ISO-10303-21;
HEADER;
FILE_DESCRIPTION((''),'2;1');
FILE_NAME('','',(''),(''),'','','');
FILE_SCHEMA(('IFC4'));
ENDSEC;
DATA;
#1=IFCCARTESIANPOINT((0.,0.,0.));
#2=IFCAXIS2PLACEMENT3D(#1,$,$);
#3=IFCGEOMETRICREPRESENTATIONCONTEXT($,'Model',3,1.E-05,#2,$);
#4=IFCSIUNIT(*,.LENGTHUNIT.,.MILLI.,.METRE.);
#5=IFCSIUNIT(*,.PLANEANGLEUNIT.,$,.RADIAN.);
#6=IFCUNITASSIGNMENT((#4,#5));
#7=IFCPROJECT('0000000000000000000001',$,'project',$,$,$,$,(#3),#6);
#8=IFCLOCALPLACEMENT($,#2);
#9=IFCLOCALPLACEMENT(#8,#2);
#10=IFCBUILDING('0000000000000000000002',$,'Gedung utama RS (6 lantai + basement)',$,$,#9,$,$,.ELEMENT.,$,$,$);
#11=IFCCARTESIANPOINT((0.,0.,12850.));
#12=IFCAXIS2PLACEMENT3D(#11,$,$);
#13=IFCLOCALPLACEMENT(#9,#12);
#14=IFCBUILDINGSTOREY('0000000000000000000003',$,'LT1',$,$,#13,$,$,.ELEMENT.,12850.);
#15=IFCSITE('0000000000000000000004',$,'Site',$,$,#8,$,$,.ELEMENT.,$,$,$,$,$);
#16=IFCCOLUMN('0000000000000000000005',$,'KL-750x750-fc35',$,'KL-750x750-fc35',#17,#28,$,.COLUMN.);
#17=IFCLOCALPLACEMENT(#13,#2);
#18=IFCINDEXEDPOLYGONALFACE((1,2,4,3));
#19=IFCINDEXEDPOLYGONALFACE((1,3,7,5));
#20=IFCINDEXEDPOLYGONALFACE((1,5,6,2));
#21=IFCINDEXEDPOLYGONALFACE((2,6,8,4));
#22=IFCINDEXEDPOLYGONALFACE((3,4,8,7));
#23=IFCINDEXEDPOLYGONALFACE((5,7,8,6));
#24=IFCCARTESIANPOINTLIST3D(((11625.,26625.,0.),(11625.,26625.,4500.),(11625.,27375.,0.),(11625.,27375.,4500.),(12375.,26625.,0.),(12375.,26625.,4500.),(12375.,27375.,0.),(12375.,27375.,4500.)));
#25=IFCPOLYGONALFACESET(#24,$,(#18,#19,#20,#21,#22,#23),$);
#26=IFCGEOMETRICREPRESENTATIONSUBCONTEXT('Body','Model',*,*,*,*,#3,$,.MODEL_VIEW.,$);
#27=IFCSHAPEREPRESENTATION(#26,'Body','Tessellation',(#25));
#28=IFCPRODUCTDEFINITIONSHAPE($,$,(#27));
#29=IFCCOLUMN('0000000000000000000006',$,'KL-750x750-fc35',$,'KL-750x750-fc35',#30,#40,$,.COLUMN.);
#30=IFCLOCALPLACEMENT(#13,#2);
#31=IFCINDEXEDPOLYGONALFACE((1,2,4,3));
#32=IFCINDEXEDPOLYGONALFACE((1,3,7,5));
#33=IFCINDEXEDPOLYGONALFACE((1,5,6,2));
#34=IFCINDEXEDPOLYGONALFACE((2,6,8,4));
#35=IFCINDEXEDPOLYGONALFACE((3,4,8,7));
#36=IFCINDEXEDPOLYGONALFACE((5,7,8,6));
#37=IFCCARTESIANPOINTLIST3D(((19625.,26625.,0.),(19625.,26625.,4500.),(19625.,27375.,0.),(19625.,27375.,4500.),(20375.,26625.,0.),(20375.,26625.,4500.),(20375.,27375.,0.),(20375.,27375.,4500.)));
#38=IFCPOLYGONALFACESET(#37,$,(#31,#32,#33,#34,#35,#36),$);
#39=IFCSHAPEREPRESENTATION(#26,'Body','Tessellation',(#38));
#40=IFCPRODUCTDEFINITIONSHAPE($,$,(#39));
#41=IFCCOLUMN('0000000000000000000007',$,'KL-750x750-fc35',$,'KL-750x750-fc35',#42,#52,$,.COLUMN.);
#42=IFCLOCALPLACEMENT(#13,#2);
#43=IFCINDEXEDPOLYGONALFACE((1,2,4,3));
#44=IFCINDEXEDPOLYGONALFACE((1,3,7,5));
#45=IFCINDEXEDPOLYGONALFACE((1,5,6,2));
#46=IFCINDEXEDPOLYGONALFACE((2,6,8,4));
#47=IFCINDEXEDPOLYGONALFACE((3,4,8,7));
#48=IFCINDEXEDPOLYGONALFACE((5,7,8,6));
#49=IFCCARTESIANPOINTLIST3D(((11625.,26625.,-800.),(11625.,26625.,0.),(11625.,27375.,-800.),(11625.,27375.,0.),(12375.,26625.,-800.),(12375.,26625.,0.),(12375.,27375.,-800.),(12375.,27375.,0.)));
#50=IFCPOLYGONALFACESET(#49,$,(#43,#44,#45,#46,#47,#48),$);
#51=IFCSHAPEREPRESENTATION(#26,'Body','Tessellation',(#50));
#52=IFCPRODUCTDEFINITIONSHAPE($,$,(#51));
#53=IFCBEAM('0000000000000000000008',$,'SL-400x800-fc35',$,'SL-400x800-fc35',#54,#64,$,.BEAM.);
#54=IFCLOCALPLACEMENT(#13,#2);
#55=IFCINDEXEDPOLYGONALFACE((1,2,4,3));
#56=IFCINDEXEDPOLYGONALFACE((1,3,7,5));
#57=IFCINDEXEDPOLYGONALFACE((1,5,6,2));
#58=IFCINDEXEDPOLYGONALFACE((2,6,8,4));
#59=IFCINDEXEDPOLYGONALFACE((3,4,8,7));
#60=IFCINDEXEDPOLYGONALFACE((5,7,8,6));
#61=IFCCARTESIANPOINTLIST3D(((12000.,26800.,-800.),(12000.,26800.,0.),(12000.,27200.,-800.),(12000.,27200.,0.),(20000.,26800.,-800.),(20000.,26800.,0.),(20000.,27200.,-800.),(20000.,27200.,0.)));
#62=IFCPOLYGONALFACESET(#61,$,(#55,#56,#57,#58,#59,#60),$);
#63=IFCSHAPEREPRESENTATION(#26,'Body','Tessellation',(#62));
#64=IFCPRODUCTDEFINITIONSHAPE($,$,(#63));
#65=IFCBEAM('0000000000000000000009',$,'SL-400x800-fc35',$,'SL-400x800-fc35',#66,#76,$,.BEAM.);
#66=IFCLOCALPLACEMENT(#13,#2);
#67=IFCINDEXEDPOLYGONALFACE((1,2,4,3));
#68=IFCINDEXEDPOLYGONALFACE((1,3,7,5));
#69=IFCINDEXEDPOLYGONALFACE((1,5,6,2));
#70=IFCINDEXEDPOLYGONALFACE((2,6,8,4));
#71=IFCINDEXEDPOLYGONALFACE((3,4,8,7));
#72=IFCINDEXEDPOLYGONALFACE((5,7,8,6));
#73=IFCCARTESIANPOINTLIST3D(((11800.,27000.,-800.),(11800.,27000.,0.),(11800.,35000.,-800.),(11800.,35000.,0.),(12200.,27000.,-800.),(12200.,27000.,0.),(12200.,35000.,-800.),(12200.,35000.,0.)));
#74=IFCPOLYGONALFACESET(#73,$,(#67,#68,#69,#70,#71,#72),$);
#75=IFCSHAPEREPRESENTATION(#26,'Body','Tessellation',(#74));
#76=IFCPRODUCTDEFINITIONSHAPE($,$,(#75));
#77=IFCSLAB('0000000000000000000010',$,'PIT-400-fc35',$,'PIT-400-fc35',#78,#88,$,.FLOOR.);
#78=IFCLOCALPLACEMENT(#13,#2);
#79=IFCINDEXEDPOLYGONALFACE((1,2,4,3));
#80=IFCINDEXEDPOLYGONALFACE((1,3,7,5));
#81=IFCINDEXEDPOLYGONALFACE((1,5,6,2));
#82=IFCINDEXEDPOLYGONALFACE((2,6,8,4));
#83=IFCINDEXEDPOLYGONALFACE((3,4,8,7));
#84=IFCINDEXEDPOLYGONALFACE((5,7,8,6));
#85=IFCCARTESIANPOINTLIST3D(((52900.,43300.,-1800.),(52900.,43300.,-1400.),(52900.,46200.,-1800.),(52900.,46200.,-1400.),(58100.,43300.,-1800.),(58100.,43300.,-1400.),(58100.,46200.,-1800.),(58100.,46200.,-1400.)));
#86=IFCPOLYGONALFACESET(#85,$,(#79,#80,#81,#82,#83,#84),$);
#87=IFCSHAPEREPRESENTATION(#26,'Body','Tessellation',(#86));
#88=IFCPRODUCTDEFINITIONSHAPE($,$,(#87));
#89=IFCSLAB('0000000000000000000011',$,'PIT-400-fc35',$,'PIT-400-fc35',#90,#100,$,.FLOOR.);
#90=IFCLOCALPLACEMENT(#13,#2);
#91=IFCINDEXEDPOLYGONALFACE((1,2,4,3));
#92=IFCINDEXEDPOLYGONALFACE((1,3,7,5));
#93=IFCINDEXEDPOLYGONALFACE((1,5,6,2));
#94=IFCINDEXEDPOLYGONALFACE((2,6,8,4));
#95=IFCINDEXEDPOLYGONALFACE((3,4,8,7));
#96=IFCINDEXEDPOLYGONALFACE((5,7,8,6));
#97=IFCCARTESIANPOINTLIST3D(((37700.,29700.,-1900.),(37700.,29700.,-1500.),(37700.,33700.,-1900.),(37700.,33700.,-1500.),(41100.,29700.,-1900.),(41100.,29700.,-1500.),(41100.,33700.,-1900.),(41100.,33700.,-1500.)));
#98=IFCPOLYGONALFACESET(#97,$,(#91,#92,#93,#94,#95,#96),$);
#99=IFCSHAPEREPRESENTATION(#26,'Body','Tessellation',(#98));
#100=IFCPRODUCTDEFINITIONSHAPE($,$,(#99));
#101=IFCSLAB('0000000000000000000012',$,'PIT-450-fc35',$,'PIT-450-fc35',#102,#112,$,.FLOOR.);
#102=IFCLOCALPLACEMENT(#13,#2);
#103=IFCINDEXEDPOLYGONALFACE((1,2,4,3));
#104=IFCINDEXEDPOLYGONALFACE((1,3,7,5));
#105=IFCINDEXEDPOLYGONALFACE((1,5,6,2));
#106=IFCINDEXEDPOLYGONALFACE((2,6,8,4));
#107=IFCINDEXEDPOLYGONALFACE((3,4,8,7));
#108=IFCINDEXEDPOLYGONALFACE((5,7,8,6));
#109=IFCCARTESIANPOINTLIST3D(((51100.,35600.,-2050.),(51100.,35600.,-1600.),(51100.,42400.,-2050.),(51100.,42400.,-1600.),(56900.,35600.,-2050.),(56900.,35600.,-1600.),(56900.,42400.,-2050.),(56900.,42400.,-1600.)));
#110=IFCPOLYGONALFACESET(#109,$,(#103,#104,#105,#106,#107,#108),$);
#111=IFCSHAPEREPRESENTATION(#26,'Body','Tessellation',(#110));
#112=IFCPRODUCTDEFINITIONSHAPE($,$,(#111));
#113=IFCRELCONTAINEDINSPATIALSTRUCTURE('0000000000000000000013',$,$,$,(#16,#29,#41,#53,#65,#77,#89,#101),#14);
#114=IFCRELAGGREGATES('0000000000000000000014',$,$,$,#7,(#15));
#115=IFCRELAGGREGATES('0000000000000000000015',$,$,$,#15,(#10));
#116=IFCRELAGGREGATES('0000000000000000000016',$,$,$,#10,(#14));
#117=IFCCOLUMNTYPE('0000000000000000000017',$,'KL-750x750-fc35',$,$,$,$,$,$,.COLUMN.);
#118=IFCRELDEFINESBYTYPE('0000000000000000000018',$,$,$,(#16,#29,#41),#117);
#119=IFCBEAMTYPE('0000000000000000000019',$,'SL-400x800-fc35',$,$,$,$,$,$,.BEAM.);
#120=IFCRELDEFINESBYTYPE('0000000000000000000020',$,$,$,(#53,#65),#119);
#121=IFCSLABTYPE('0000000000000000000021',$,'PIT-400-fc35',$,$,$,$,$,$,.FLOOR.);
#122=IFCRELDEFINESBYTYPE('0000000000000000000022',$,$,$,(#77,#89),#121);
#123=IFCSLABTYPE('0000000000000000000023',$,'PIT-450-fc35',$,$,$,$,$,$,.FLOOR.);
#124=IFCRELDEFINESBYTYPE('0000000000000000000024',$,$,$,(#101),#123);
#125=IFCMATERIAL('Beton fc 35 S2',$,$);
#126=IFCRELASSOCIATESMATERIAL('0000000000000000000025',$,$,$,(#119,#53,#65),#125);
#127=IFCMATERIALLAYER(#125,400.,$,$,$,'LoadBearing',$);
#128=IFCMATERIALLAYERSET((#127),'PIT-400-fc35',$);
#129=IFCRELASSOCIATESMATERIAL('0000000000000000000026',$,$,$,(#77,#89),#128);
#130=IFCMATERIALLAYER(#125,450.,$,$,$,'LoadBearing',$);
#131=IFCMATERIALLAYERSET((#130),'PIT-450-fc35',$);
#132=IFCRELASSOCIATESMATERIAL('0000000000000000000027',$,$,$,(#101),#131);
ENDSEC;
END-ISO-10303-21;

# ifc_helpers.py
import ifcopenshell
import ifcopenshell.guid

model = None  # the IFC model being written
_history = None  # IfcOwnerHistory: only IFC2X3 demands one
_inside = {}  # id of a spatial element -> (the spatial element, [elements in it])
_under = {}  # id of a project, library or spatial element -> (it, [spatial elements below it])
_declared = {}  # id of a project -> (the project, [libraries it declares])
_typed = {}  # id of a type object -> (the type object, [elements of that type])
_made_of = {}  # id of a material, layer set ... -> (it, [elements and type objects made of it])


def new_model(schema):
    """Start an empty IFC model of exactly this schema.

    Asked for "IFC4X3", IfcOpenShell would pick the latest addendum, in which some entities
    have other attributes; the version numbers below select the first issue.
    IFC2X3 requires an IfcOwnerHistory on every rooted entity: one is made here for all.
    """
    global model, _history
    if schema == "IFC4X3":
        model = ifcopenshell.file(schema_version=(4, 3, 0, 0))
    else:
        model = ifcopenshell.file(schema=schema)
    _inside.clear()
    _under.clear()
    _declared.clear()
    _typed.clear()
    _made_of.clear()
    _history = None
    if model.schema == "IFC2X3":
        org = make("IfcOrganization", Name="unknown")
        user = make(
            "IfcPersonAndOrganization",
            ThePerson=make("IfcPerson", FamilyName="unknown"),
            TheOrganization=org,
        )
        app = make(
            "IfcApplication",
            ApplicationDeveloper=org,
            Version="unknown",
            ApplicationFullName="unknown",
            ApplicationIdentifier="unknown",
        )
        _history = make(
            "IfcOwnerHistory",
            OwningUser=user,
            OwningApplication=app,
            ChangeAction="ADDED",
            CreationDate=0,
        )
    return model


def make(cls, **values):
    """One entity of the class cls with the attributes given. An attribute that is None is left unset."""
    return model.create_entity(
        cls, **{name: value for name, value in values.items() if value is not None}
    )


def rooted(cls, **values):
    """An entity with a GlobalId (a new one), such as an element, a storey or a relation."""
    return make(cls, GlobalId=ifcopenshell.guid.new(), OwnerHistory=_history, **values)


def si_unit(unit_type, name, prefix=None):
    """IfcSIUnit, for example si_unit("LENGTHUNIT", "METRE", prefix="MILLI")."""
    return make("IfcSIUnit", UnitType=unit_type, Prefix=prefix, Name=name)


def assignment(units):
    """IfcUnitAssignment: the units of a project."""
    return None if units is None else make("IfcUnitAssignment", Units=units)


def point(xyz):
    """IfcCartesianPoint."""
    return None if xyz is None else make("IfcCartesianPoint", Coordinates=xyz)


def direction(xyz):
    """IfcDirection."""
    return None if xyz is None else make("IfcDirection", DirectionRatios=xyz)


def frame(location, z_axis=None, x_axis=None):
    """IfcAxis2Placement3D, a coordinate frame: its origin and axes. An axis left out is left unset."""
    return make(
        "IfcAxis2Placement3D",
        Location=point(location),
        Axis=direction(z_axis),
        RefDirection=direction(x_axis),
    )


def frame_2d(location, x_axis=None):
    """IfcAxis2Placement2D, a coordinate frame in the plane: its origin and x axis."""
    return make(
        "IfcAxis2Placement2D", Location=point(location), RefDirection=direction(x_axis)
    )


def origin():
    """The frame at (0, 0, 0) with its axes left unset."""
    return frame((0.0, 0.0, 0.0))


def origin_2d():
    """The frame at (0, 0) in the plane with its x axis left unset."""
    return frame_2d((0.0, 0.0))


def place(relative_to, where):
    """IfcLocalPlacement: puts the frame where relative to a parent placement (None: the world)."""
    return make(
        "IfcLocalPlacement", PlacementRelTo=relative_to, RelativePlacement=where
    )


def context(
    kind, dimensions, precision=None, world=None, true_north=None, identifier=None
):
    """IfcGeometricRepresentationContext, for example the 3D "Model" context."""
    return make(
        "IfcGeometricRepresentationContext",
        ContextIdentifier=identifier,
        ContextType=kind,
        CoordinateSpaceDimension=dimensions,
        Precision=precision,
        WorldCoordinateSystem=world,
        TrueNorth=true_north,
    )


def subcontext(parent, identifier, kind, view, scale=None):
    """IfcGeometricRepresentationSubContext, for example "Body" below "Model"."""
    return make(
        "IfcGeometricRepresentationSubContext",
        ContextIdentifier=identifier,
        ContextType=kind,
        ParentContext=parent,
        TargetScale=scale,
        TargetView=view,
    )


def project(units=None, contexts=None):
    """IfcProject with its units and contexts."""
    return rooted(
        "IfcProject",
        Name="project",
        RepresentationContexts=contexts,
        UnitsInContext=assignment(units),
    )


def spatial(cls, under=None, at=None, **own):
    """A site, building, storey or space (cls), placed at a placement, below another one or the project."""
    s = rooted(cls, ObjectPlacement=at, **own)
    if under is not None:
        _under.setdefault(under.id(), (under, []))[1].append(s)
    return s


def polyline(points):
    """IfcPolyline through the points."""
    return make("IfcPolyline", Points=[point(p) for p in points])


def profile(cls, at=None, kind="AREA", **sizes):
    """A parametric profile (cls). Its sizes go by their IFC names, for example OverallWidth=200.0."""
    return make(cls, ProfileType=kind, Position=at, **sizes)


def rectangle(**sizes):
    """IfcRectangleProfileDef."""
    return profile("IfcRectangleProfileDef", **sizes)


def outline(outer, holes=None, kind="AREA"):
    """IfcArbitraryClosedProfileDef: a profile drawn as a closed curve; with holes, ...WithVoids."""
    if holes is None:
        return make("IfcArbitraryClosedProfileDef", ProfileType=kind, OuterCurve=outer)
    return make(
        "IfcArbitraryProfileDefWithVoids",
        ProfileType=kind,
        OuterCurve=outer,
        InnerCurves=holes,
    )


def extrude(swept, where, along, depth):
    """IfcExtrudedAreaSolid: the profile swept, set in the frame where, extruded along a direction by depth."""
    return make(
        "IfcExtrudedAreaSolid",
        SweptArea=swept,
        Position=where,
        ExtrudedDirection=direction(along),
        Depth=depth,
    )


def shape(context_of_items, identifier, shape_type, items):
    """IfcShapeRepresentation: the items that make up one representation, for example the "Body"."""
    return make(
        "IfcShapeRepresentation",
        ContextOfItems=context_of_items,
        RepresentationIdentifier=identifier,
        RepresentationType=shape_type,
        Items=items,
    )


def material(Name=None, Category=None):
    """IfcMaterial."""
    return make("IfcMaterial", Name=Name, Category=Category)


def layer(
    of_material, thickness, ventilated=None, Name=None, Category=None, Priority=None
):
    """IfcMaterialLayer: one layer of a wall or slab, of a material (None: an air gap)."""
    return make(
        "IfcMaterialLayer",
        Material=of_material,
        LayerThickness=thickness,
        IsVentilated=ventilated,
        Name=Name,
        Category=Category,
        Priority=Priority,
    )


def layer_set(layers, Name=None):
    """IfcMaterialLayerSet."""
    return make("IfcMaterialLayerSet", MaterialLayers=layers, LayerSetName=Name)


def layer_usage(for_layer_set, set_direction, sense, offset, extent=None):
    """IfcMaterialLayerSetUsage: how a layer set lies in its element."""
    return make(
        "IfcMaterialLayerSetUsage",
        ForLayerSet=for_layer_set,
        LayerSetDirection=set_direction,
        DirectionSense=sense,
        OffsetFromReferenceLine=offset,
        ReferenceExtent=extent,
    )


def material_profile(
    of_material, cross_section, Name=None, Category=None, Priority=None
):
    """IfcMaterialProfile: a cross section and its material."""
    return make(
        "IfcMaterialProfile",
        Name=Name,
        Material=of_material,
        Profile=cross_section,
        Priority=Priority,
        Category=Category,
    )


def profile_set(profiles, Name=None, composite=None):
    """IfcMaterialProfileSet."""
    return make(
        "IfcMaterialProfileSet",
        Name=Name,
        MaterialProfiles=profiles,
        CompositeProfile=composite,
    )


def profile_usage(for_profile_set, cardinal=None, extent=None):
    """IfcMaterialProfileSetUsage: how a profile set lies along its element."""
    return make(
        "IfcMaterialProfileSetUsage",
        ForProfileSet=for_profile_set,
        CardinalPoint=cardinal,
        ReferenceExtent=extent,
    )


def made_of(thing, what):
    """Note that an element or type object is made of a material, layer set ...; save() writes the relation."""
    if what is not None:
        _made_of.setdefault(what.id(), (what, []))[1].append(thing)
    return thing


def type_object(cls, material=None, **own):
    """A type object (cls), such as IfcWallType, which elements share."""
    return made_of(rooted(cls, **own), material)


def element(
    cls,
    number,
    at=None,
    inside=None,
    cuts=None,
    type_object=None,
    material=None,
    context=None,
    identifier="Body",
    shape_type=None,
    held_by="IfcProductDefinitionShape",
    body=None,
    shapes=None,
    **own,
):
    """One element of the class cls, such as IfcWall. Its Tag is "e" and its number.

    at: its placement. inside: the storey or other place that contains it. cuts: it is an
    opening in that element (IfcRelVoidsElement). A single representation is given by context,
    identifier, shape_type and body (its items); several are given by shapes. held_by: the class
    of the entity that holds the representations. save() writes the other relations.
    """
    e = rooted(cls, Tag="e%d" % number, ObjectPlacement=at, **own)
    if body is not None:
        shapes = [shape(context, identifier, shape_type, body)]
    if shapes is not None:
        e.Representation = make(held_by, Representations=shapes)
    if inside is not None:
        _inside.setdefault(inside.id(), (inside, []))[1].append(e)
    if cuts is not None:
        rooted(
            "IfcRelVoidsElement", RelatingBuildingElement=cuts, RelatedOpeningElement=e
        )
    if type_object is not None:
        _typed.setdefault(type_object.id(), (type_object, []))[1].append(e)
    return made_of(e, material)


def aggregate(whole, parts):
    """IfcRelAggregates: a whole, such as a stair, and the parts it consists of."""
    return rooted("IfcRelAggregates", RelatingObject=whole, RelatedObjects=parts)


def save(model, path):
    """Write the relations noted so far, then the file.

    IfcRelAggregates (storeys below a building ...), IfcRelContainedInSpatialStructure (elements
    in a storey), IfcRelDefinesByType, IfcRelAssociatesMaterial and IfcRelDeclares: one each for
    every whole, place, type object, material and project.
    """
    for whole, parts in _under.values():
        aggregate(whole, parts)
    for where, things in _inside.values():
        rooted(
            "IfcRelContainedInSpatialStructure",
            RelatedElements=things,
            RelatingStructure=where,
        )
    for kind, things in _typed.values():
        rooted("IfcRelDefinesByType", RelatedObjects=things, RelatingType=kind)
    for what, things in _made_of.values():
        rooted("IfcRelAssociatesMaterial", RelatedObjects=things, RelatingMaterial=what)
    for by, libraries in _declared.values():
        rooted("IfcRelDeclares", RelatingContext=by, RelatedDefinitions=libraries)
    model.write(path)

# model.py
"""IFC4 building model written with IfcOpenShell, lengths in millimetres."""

from ifc_helpers import new_model, si_unit, frame, origin, origin_2d, place, context, subcontext, project, spatial, polyline, rectangle, outline, extrude, material, layer, layer_set, layer_usage, material_profile, profile_set, profile_usage, type_object, element, save


model = new_model("IFC4")

# Units and contexts
model_context = context("Model", 3, precision=1e-05, world=origin())
body_context = subcontext(model_context, "Body", "Model", "MODEL_VIEW")
ifc_project = project(units=[si_unit("LENGTHUNIT", "METRE", prefix="MILLI"), si_unit("PLANEANGLEUNIT", "RADIAN")], contexts=[model_context])

# Site, building, storey
site_placement = place(None, origin())
site = spatial("IfcSite", under=ifc_project, at=site_placement, Name="Site", CompositionType="ELEMENT")
building_placement = place(site_placement, origin())
building = spatial("IfcBuilding", under=site, at=building_placement, Name="Gedung utama RS (6 lantai + basement)", CompositionType="ELEMENT")
storey_placement = place(building_placement, frame((0.0, 0.0, 12850.0)))
storey = spatial("IfcBuildingStorey", under=building, at=storey_placement, Name="LT1", CompositionType="ELEMENT", Elevation=12850.0)

# Columns
ifc_material_profile_1 = material_profile(None, rectangle(XDim=750.0, YDim=750.0, at=origin_2d()), Name="KL-750x750-fc35")
ifc_profile_set_1 = profile_set([ifc_material_profile_1], Name="KL-750x750-fc35")
ifc_profile_usage_1 = profile_usage(ifc_profile_set_1, cardinal=5)
column_type = type_object("IfcColumnType", Name="KL-750x750-fc35", PredefinedType="COLUMN", material=ifc_profile_set_1)
for number, where, z_axis, x_axis, name in (
    (1, (12000.0, 27000.0, 0.0), (0.0, 0.0, 1.0), (1.0, 0.0, 0.0), "KL-750x750-fc35"),
    (2, (20000.0, 27000.0, 0.0), (0.0, 0.0, 1.0), (1.0, 0.0, 0.0), "KL-750x750-fc35"),
):
    element("IfcColumn", number, at=place(storey_placement, frame(where, z_axis=z_axis, x_axis=x_axis)), inside=storey, type_object=column_type, material=ifc_profile_usage_1, Name=name, ObjectType="KL-750x750-fc35", PredefinedType="COLUMN", context=body_context, shape_type="SweptSolid", body=[
        extrude(rectangle(XDim=750.0, YDim=750.0, at=origin_2d()), origin(), (0.0, 0.0, 1.0), 4500.0),
    ])
column_placement = place(storey_placement, frame((12000.0, 27000.0, -800.0), z_axis=(0.0, 0.0, 1.0), x_axis=(1.0, 0.0, 0.0)))
element("IfcColumn", 3, at=column_placement, inside=storey, type_object=column_type, material=ifc_profile_usage_1, Name="KL-750x750-fc35", ObjectType="KL-750x750-fc35", PredefinedType="COLUMN", context=body_context, shape_type="SweptSolid", body=[
    extrude(rectangle(XDim=750.0, YDim=750.0, at=origin_2d()), origin(), (0.0, 0.0, 1.0), 800.0),
])

# Beams
ifc_material_1 = material(Name="Beton fc 35 S2")
ifc_material_profile_2 = material_profile(ifc_material_1, rectangle(XDim=400.0, YDim=800.0, at=origin_2d()), Name="SL-400x800-fc35")
ifc_profile_set_2 = profile_set([ifc_material_profile_2], Name="SL-400x800-fc35")
ifc_profile_usage_2 = profile_usage(ifc_profile_set_2, cardinal=8)
beam_type = type_object("IfcBeamType", Name="SL-400x800-fc35", PredefinedType="BEAM", material=ifc_profile_set_2)
beam_1_placement = place(storey_placement, frame((12000.0, 27000.0, -400.0)))
element("IfcBeam", 4, at=beam_1_placement, inside=storey, type_object=beam_type, material=ifc_profile_usage_2, Name="SL-400x800-fc35", ObjectType="SL-400x800-fc35", PredefinedType="BEAM", context=body_context, shape_type="SweptSolid", body=[
    extrude(rectangle(XDim=400.0, YDim=800.0, at=origin_2d()), frame((0.0, 0.0, 0.0), z_axis=(1.0, 0.0, 0.0), x_axis=(0.0, 1.0, 0.0)), (0.0, 0.0, 1.0), 8000.0),
])
beam_2_placement = place(storey_placement, frame((12000.0, 27000.0, -400.0)))
element("IfcBeam", 5, at=beam_2_placement, inside=storey, type_object=beam_type, material=ifc_profile_usage_2, Name="SL-400x800-fc35", ObjectType="SL-400x800-fc35", PredefinedType="BEAM", context=body_context, shape_type="SweptSolid", body=[
    extrude(rectangle(XDim=400.0, YDim=800.0, at=origin_2d()), frame((0.0, 0.0, 0.0), z_axis=(0.0, 1.0, 0.0), x_axis=(-1.0, 0.0, 0.0)), (0.0, 0.0, 1.0), 8000.0),
])

# Slabs
ifc_layer_1 = layer(ifc_material_1, 400.0, Category="LoadBearing")
ifc_layer_set_1 = layer_set([ifc_layer_1], Name="PIT-400-fc35")
ifc_layer_usage_1 = layer_usage(ifc_layer_set_1, "AXIS3", "NEGATIVE", -1400.0)
slab_type_1 = type_object("IfcSlabType", Name="PIT-400-fc35", PredefinedType="FLOOR")
slab_1_placement = place(storey_placement, origin())
element("IfcSlab", 6, at=slab_1_placement, inside=storey, type_object=slab_type_1, material=ifc_layer_usage_1, Name="PIT-400-fc35", ObjectType="PIT-400-fc35", PredefinedType="FLOOR", context=body_context, shape_type="SweptSolid", body=[
    extrude(outline(polyline([(58100.0, 43300.0), (58100.0, 46200.0), (52900.0, 46200.0), (52900.0, 43300.0), (58100.0, 43300.0)])), frame((0.0, 0.0, -1800.0)), (0.0, 0.0, 1.0), 400.0),
])
ifc_layer_usage_2 = layer_usage(ifc_layer_set_1, "AXIS3", "NEGATIVE", -1500.0)
slab_2_placement = place(storey_placement, origin())
element("IfcSlab", 7, at=slab_2_placement, inside=storey, type_object=slab_type_1, material=ifc_layer_usage_2, Name="PIT-400-fc35", ObjectType="PIT-400-fc35", PredefinedType="FLOOR", context=body_context, shape_type="SweptSolid", body=[
    extrude(outline(polyline([(41100.0, 29700.0), (41100.0, 33700.0), (37700.0, 33700.0), (37700.0, 29700.0), (41100.0, 29700.0)])), frame((0.0, 0.0, -1900.0)), (0.0, 0.0, 1.0), 400.0),
])
ifc_layer_2 = layer(ifc_material_1, 450.0, Category="LoadBearing")
ifc_layer_set_2 = layer_set([ifc_layer_2], Name="PIT-450-fc35")
ifc_layer_usage_3 = layer_usage(ifc_layer_set_2, "AXIS3", "NEGATIVE", -1600.0)
slab_type_2 = type_object("IfcSlabType", Name="PIT-450-fc35", PredefinedType="FLOOR")
slab_3_placement = place(storey_placement, origin())
element("IfcSlab", 8, at=slab_3_placement, inside=storey, type_object=slab_type_2, material=ifc_layer_usage_3, Name="PIT-450-fc35", ObjectType="PIT-450-fc35", PredefinedType="FLOOR", context=body_context, shape_type="SweptSolid", body=[
    extrude(outline(polyline([(56900.0, 35600.0), (56900.0, 42400.0), (51100.0, 42400.0), (51100.0, 35600.0), (56900.0, 35600.0)])), frame((0.0, 0.0, -2050.0)), (0.0, 0.0, 1.0), 450.0),
])

save(model, "model.ifc")
